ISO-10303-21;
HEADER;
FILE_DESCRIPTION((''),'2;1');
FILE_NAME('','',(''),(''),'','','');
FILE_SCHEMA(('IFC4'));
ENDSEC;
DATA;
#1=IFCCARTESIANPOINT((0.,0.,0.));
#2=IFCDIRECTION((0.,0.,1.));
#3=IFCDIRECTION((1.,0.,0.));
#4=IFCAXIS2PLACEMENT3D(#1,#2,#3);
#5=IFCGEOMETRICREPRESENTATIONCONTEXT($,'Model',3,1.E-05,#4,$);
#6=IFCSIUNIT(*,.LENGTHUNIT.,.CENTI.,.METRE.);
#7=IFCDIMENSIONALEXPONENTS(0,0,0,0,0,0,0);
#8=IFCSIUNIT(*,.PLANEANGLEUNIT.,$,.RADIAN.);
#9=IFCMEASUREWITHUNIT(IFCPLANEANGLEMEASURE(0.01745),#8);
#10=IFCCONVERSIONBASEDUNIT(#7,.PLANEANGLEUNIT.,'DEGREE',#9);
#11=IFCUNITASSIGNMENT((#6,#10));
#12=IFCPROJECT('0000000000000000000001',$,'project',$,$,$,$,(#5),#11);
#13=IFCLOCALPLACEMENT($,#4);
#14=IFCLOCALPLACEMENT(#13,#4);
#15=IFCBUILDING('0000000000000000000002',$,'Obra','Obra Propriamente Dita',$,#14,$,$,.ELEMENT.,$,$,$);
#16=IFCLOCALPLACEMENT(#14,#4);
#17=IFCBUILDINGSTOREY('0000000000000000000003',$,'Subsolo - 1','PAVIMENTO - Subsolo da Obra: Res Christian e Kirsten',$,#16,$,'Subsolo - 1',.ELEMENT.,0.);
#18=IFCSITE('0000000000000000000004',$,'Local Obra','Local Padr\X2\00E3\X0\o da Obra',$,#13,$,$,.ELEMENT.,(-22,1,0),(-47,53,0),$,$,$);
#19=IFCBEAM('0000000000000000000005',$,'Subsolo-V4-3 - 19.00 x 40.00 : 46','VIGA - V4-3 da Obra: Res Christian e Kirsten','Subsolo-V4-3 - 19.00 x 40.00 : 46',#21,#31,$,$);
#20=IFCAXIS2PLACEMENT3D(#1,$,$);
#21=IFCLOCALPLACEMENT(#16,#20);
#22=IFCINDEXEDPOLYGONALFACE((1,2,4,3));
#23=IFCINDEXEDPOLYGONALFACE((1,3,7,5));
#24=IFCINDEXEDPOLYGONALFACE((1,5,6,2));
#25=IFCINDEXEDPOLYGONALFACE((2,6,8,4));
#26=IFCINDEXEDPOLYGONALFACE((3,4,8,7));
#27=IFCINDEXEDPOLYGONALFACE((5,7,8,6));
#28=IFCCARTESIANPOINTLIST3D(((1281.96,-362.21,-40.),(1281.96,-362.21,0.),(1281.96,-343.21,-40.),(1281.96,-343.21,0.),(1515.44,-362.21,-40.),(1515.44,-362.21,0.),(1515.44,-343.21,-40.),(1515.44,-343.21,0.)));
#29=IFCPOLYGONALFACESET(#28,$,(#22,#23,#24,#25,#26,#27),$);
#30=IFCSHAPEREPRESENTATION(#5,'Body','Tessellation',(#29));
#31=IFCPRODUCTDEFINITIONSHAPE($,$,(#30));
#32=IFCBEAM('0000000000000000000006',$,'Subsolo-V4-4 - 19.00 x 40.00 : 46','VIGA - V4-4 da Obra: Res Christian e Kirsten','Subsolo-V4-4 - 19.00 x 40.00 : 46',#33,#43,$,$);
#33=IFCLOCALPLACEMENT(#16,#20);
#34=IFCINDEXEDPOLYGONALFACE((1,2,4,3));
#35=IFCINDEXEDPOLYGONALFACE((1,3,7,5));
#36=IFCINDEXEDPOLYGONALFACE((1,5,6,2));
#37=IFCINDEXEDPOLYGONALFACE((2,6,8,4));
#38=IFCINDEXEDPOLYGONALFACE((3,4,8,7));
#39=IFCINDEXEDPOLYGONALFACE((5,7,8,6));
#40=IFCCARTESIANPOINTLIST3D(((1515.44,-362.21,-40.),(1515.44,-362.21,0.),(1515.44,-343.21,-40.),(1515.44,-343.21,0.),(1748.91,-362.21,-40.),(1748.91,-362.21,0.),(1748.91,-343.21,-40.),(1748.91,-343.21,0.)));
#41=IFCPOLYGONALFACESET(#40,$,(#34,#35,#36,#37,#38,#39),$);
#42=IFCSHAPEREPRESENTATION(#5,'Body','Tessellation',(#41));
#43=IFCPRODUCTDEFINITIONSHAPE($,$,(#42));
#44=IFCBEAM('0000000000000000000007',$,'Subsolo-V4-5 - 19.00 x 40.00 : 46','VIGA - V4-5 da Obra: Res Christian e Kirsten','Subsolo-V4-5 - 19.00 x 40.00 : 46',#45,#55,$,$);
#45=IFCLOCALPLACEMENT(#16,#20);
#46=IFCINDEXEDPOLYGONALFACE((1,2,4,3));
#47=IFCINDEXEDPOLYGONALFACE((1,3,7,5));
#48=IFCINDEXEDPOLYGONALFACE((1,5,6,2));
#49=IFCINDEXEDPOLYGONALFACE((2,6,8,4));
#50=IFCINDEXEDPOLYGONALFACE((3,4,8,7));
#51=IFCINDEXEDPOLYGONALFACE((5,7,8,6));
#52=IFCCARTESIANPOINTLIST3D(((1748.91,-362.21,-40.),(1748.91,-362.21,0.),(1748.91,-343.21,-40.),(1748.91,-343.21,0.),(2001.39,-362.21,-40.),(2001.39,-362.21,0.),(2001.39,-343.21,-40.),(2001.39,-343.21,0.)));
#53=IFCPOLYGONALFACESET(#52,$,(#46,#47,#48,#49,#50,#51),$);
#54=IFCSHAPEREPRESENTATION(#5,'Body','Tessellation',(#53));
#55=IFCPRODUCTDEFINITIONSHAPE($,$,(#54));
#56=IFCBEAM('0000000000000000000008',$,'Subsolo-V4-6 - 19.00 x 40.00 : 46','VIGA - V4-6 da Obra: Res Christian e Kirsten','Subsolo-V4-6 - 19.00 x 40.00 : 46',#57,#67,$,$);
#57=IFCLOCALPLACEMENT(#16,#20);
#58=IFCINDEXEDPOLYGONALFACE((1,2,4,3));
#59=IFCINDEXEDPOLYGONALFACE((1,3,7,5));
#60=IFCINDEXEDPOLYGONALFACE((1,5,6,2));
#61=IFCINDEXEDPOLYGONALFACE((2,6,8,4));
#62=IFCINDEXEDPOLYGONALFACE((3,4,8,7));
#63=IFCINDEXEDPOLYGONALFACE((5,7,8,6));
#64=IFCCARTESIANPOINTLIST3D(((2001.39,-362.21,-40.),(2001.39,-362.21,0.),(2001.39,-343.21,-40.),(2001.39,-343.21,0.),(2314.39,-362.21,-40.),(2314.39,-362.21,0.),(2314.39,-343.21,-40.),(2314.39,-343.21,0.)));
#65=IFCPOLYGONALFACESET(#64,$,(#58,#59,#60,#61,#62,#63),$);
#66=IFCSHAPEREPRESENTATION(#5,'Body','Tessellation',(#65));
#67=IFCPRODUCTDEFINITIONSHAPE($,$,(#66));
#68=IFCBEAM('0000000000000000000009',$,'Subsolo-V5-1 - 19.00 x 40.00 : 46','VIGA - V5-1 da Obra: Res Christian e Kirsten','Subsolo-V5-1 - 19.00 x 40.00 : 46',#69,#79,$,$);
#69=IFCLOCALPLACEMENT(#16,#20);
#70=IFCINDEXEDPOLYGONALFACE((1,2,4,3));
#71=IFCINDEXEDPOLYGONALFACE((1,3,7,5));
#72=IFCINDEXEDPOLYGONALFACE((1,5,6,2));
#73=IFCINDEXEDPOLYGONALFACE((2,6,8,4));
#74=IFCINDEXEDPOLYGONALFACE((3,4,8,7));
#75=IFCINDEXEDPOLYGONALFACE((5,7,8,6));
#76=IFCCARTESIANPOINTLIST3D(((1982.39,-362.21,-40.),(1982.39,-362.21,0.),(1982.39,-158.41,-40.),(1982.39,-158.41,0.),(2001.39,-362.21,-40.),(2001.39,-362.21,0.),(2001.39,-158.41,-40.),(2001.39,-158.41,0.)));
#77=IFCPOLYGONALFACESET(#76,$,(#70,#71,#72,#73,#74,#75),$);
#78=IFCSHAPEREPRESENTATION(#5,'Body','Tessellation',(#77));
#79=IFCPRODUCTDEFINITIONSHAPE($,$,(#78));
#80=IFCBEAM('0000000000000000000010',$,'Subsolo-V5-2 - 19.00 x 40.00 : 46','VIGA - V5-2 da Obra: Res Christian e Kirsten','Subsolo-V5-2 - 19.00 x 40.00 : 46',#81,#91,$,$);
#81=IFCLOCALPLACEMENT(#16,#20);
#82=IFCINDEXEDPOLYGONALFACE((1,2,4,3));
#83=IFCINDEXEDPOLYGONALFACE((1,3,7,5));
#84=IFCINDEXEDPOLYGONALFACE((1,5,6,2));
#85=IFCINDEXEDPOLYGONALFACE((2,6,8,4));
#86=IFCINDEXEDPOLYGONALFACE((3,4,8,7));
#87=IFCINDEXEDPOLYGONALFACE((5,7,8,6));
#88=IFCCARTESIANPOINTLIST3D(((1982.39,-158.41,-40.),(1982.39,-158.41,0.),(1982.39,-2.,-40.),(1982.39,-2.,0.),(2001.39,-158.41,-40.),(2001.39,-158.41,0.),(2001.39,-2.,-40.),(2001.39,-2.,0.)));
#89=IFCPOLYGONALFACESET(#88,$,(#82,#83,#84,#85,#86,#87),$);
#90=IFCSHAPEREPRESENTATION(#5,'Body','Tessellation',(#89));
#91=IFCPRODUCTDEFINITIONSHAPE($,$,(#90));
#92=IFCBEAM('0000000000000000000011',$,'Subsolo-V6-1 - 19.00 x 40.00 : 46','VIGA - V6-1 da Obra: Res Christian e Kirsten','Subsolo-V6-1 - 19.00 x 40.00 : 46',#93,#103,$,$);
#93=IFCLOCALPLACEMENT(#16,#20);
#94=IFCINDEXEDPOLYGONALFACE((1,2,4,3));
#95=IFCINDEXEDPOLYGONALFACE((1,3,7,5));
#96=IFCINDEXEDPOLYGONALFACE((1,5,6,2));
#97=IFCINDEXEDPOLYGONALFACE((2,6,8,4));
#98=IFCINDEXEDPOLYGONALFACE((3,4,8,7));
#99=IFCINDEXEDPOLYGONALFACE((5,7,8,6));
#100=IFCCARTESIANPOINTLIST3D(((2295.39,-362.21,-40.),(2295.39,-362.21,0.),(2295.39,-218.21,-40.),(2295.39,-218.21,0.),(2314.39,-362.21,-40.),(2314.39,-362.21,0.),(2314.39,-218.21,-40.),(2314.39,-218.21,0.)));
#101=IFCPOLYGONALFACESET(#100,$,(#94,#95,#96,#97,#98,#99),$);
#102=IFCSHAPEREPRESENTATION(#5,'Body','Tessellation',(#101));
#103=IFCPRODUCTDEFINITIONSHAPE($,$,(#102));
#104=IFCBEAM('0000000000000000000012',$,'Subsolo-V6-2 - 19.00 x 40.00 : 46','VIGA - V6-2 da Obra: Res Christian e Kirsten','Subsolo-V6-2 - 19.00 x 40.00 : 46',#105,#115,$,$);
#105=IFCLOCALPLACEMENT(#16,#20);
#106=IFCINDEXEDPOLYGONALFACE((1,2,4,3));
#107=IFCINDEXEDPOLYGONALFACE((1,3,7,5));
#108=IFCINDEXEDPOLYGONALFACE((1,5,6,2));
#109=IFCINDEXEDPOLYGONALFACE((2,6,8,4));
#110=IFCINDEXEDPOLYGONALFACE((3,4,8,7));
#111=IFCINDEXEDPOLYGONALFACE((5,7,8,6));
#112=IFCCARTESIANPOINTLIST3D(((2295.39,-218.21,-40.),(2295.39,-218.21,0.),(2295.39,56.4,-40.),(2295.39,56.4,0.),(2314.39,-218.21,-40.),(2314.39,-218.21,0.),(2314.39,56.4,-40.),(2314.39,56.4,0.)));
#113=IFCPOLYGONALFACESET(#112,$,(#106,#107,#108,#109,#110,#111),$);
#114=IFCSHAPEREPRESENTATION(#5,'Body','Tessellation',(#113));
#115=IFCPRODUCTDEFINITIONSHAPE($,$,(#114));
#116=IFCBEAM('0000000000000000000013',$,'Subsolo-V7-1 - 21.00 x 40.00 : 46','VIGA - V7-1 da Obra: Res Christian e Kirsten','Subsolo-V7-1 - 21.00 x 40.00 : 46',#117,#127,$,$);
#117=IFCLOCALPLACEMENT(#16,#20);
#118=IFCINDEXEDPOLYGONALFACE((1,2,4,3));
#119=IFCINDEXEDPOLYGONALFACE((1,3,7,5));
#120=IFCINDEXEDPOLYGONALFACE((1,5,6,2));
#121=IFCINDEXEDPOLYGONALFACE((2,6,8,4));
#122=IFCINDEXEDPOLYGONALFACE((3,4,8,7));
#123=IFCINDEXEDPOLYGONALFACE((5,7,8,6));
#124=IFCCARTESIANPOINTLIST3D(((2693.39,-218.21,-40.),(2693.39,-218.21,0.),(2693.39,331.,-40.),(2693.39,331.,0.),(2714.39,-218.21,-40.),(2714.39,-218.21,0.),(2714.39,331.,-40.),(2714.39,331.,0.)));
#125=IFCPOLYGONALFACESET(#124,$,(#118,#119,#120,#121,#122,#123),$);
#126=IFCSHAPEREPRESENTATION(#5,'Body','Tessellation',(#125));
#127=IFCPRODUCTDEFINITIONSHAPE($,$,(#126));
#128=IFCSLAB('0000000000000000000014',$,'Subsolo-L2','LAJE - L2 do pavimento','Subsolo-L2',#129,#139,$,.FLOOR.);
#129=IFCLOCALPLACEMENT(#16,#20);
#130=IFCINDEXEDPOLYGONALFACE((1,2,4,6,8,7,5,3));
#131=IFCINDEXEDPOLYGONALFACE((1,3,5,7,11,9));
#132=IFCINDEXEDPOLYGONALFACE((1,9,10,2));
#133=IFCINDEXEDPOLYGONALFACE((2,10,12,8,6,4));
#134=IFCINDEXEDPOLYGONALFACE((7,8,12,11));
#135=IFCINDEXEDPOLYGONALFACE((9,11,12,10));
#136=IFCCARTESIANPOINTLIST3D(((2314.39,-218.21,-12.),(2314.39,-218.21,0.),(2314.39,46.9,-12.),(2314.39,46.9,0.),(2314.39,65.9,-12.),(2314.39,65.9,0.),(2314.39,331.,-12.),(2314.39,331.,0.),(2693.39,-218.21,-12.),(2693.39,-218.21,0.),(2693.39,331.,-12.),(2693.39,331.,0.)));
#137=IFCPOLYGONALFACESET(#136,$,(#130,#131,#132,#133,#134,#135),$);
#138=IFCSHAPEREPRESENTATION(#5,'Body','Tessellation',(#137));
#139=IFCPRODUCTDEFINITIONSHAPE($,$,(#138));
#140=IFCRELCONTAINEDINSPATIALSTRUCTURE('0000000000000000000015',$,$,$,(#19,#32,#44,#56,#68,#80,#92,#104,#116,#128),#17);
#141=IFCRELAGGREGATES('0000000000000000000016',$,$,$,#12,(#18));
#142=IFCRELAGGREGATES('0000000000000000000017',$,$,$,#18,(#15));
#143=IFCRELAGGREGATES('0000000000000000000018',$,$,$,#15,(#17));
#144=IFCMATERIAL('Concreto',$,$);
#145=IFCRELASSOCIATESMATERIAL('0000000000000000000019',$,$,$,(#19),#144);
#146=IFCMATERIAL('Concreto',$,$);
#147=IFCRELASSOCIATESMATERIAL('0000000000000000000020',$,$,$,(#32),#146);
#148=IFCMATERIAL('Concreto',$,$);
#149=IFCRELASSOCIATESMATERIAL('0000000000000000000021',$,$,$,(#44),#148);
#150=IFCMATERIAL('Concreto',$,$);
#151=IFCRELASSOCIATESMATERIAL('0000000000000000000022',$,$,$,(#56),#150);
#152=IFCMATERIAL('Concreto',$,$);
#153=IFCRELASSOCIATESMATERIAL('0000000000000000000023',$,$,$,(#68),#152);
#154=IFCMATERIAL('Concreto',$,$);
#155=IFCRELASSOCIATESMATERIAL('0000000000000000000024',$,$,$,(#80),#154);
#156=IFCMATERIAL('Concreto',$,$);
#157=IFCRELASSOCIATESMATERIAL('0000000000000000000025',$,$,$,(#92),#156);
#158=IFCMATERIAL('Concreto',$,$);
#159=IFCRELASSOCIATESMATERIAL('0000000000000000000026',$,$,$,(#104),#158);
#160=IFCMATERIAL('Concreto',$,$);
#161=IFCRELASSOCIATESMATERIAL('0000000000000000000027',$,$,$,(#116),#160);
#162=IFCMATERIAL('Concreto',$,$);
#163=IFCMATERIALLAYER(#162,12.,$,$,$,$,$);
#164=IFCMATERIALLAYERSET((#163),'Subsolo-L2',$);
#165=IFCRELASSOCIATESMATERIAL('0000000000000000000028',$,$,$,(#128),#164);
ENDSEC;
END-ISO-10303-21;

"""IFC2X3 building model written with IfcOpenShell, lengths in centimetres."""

from ifc_helpers import new_model, entity, si_unit, converted_unit, frame, origin_with_axes, place, context, project, spatial, polyline, outline, extrude, material, layer, layer_set, layer_usage, element, save


model = new_model("IFC2X3")

# Units and contexts
model_context = context("Model", 3, precision=1e-05, world=origin_with_axes())
ifc_project = project(units=[si_unit("LENGTHUNIT", "METRE", prefix="CENTI"), converted_unit("PLANEANGLEUNIT", "DEGREE", entity("IfcPlaneAngleMeasure", 0.01745), si_unit("PLANEANGLEUNIT", "RADIAN"), dimensions=[0, 0, 0, 0, 0, 0, 0])], contexts=[model_context])

# Site, building, storey
site_placement = place(None, origin_with_axes())
site = spatial("IfcSite", under=ifc_project, at=site_placement, Name="Local Obra", Description="Local Padrão da Obra", CompositionType="ELEMENT", RefLatitude=(-22, 1, 0), RefLongitude=(-47, 53, 0))
building_placement = place(site_placement, origin_with_axes())
building = spatial("IfcBuilding", under=site, at=building_placement, Name="Obra", Description="Obra Propriamente Dita", CompositionType="ELEMENT")
storey_placement = place(building_placement, origin_with_axes())
storey = spatial("IfcBuildingStorey", under=building, at=storey_placement, Name="Subsolo - 1", Description="PAVIMENTO - Subsolo da Obra: Res Christian e Kirsten", LongName="Subsolo - 1", CompositionType="ELEMENT", Elevation=0.0)

# Beams
ifc_material_1 = material(Name="Concreto")
beam_1_placement = place(storey_placement, frame((1281.96, -362.21, 0.0), z_axis=(1.0, 0.0, 0.0), x_axis=(0.0, -1.0, 0.0)))
element("IfcBeam", 1, at=beam_1_placement, inside=storey, material=ifc_material_1, Name="Subsolo-V4-3 - 19.00 x 40.00 : 46", Description="VIGA - V4-3 da Obra: Res Christian e Kirsten", ObjectType="Subsolo-V4-3 - 19.00 x 40.00 : 46", context=model_context, shape_type="SweptSolid", body=[
    extrude(outline(polyline([(-19.0, 0.0), (0.0, 0.0), (0.0, 40.0), (-19.0, 40.0), (-19.0, 0.0)])), origin_with_axes(), (0.0, 0.0, 1.0), 233.48),
])
ifc_material_2 = material(Name="Concreto")
beam_2_placement = place(storey_placement, frame((1515.44, -362.21, 0.0), z_axis=(1.0, 0.0, 0.0), x_axis=(0.0, -1.0, 0.0)))
element("IfcBeam", 2, at=beam_2_placement, inside=storey, material=ifc_material_2, Name="Subsolo-V4-4 - 19.00 x 40.00 : 46", Description="VIGA - V4-4 da Obra: Res Christian e Kirsten", ObjectType="Subsolo-V4-4 - 19.00 x 40.00 : 46", context=model_context, shape_type="SweptSolid", body=[
    extrude(outline(polyline([(-19.0, 0.0), (0.0, 0.0), (0.0, 40.0), (-19.0, 40.0), (-19.0, 0.0)])), origin_with_axes(), (0.0, 0.0, 1.0), 233.48),
])
ifc_material_3 = material(Name="Concreto")
beam_3_placement = place(storey_placement, frame((1748.91, -362.21, 0.0), z_axis=(1.0, 0.0, 0.0), x_axis=(0.0, -1.0, 0.0)))
element("IfcBeam", 3, at=beam_3_placement, inside=storey, material=ifc_material_3, Name="Subsolo-V4-5 - 19.00 x 40.00 : 46", Description="VIGA - V4-5 da Obra: Res Christian e Kirsten", ObjectType="Subsolo-V4-5 - 19.00 x 40.00 : 46", context=model_context, shape_type="SweptSolid", body=[
    extrude(outline(polyline([(-19.0, 0.0), (0.0, 0.0), (0.0, 40.0), (-19.0, 40.0), (-19.0, 0.0)])), origin_with_axes(), (0.0, 0.0, 1.0), 252.48),
])
ifc_material_4 = material(Name="Concreto")
beam_4_placement = place(storey_placement, frame((2001.39, -362.21, 0.0), z_axis=(1.0, 0.0, 0.0), x_axis=(0.0, -1.0, 0.0)))
element("IfcBeam", 4, at=beam_4_placement, inside=storey, material=ifc_material_4, Name="Subsolo-V4-6 - 19.00 x 40.00 : 46", Description="VIGA - V4-6 da Obra: Res Christian e Kirsten", ObjectType="Subsolo-V4-6 - 19.00 x 40.00 : 46", context=model_context, shape_type="SweptSolid", body=[
    extrude(outline(polyline([(-19.0, 0.0), (0.0, 0.0), (0.0, 40.0), (-19.0, 40.0), (-19.0, 0.0)])), origin_with_axes(), (0.0, 0.0, 1.0), 313.0),
])
ifc_material_5 = material(Name="Concreto")
beam_5_placement = place(storey_placement, frame((2001.39, -362.21, 0.0), z_axis=(0.0, 1.0, 0.0), x_axis=(1.0, 0.0, 0.0)))
element("IfcBeam", 5, at=beam_5_placement, inside=storey, material=ifc_material_5, Name="Subsolo-V5-1 - 19.00 x 40.00 : 46", Description="VIGA - V5-1 da Obra: Res Christian e Kirsten", ObjectType="Subsolo-V5-1 - 19.00 x 40.00 : 46", context=model_context, shape_type="SweptSolid", body=[
    extrude(outline(polyline([(-19.0, 0.0), (0.0, 0.0), (0.0, 40.0), (-19.0, 40.0), (-19.0, 0.0)])), origin_with_axes(), (0.0, 0.0, 1.0), 203.8),
])
ifc_material_6 = material(Name="Concreto")
beam_6_placement = place(storey_placement, frame((2001.39, -158.41, 0.0), z_axis=(0.0, 1.0, 0.0), x_axis=(1.0, 0.0, 0.0)))
element("IfcBeam", 6, at=beam_6_placement, inside=storey, material=ifc_material_6, Name="Subsolo-V5-2 - 19.00 x 40.00 : 46", Description="VIGA - V5-2 da Obra: Res Christian e Kirsten", ObjectType="Subsolo-V5-2 - 19.00 x 40.00 : 46", context=model_context, shape_type="SweptSolid", body=[
    extrude(outline(polyline([(-19.0, 0.0), (0.0, 0.0), (0.0, 40.0), (-19.0, 40.0), (-19.0, 0.0)])), origin_with_axes(), (0.0, 0.0, 1.0), 156.41),
])
ifc_material_7 = material(Name="Concreto")
beam_7_placement = place(storey_placement, frame((2314.39, -362.21, 0.0), z_axis=(0.0, 1.0, 0.0), x_axis=(1.0, 0.0, 0.0)))
element("IfcBeam", 7, at=beam_7_placement, inside=storey, material=ifc_material_7, Name="Subsolo-V6-1 - 19.00 x 40.00 : 46", Description="VIGA - V6-1 da Obra: Res Christian e Kirsten", ObjectType="Subsolo-V6-1 - 19.00 x 40.00 : 46", context=model_context, shape_type="SweptSolid", body=[
    extrude(outline(polyline([(-19.0, 0.0), (0.0, 0.0), (0.0, 40.0), (-19.0, 40.0), (-19.0, 0.0)])), origin_with_axes(), (0.0, 0.0, 1.0), 144.0),
])
ifc_material_8 = material(Name="Concreto")
beam_8_placement = place(storey_placement, frame((2314.39, -218.21, 0.0), z_axis=(0.0, 1.0, 0.0), x_axis=(1.0, 0.0, 0.0)))
element("IfcBeam", 8, at=beam_8_placement, inside=storey, material=ifc_material_8, Name="Subsolo-V6-2 - 19.00 x 40.00 : 46", Description="VIGA - V6-2 da Obra: Res Christian e Kirsten", ObjectType="Subsolo-V6-2 - 19.00 x 40.00 : 46", context=model_context, shape_type="SweptSolid", body=[
    extrude(outline(polyline([(-19.0, 0.0), (0.0, 0.0), (0.0, 40.0), (-19.0, 40.0), (-19.0, 0.0)])), origin_with_axes(), (0.0, 0.0, 1.0), 274.6),
])
ifc_material_9 = material(Name="Concreto")
beam_9_placement = place(storey_placement, frame((2714.39, -218.21, 0.0), z_axis=(0.0, 1.0, 0.0), x_axis=(1.0, 0.0, 0.0)))
element("IfcBeam", 9, at=beam_9_placement, inside=storey, material=ifc_material_9, Name="Subsolo-V7-1 - 21.00 x 40.00 : 46", Description="VIGA - V7-1 da Obra: Res Christian e Kirsten", ObjectType="Subsolo-V7-1 - 21.00 x 40.00 : 46", context=model_context, shape_type="SweptSolid", body=[
    extrude(outline(polyline([(-21.0, 0.0), (0.0, 0.0), (0.0, 40.0), (-21.0, 40.0), (-21.0, 0.0)])), origin_with_axes(), (0.0, 0.0, 1.0), 549.21),
])

# Slab
ifc_material_10 = material(Name="Concreto")
ifc_layer = layer(ifc_material_10, 12.0)
ifc_layer_set = layer_set([ifc_layer], Name="Subsolo-L2")
ifc_layer_usage = layer_usage(ifc_layer_set, "AXIS3", "POSITIVE", 0.0)
slab_placement = place(storey_placement, frame((2693.39, -218.21, -12.0), z_axis=(0.0, 0.0, 1.0), x_axis=(1.0, 0.0, 0.0)))
element("IfcSlab", 10, at=slab_placement, inside=storey, material=ifc_layer_usage, Name="Subsolo-L2", Description="LAJE - L2 do pavimento", ObjectType="Subsolo-L2", PredefinedType="FLOOR", context=model_context, shape_type="SweptSolid", body=[
    extrude(outline(polyline([(0.0, 549.21), (-379.0, 549.21), (-379.0, 284.11), (-379.0, 265.11), (-379.0, 0.0), (0.0, 0.0), (0.0, 549.21)])), origin_with_axes(), (0.0, 0.0, 1.0), 12.0),
])

save(model, "model.ifc")
